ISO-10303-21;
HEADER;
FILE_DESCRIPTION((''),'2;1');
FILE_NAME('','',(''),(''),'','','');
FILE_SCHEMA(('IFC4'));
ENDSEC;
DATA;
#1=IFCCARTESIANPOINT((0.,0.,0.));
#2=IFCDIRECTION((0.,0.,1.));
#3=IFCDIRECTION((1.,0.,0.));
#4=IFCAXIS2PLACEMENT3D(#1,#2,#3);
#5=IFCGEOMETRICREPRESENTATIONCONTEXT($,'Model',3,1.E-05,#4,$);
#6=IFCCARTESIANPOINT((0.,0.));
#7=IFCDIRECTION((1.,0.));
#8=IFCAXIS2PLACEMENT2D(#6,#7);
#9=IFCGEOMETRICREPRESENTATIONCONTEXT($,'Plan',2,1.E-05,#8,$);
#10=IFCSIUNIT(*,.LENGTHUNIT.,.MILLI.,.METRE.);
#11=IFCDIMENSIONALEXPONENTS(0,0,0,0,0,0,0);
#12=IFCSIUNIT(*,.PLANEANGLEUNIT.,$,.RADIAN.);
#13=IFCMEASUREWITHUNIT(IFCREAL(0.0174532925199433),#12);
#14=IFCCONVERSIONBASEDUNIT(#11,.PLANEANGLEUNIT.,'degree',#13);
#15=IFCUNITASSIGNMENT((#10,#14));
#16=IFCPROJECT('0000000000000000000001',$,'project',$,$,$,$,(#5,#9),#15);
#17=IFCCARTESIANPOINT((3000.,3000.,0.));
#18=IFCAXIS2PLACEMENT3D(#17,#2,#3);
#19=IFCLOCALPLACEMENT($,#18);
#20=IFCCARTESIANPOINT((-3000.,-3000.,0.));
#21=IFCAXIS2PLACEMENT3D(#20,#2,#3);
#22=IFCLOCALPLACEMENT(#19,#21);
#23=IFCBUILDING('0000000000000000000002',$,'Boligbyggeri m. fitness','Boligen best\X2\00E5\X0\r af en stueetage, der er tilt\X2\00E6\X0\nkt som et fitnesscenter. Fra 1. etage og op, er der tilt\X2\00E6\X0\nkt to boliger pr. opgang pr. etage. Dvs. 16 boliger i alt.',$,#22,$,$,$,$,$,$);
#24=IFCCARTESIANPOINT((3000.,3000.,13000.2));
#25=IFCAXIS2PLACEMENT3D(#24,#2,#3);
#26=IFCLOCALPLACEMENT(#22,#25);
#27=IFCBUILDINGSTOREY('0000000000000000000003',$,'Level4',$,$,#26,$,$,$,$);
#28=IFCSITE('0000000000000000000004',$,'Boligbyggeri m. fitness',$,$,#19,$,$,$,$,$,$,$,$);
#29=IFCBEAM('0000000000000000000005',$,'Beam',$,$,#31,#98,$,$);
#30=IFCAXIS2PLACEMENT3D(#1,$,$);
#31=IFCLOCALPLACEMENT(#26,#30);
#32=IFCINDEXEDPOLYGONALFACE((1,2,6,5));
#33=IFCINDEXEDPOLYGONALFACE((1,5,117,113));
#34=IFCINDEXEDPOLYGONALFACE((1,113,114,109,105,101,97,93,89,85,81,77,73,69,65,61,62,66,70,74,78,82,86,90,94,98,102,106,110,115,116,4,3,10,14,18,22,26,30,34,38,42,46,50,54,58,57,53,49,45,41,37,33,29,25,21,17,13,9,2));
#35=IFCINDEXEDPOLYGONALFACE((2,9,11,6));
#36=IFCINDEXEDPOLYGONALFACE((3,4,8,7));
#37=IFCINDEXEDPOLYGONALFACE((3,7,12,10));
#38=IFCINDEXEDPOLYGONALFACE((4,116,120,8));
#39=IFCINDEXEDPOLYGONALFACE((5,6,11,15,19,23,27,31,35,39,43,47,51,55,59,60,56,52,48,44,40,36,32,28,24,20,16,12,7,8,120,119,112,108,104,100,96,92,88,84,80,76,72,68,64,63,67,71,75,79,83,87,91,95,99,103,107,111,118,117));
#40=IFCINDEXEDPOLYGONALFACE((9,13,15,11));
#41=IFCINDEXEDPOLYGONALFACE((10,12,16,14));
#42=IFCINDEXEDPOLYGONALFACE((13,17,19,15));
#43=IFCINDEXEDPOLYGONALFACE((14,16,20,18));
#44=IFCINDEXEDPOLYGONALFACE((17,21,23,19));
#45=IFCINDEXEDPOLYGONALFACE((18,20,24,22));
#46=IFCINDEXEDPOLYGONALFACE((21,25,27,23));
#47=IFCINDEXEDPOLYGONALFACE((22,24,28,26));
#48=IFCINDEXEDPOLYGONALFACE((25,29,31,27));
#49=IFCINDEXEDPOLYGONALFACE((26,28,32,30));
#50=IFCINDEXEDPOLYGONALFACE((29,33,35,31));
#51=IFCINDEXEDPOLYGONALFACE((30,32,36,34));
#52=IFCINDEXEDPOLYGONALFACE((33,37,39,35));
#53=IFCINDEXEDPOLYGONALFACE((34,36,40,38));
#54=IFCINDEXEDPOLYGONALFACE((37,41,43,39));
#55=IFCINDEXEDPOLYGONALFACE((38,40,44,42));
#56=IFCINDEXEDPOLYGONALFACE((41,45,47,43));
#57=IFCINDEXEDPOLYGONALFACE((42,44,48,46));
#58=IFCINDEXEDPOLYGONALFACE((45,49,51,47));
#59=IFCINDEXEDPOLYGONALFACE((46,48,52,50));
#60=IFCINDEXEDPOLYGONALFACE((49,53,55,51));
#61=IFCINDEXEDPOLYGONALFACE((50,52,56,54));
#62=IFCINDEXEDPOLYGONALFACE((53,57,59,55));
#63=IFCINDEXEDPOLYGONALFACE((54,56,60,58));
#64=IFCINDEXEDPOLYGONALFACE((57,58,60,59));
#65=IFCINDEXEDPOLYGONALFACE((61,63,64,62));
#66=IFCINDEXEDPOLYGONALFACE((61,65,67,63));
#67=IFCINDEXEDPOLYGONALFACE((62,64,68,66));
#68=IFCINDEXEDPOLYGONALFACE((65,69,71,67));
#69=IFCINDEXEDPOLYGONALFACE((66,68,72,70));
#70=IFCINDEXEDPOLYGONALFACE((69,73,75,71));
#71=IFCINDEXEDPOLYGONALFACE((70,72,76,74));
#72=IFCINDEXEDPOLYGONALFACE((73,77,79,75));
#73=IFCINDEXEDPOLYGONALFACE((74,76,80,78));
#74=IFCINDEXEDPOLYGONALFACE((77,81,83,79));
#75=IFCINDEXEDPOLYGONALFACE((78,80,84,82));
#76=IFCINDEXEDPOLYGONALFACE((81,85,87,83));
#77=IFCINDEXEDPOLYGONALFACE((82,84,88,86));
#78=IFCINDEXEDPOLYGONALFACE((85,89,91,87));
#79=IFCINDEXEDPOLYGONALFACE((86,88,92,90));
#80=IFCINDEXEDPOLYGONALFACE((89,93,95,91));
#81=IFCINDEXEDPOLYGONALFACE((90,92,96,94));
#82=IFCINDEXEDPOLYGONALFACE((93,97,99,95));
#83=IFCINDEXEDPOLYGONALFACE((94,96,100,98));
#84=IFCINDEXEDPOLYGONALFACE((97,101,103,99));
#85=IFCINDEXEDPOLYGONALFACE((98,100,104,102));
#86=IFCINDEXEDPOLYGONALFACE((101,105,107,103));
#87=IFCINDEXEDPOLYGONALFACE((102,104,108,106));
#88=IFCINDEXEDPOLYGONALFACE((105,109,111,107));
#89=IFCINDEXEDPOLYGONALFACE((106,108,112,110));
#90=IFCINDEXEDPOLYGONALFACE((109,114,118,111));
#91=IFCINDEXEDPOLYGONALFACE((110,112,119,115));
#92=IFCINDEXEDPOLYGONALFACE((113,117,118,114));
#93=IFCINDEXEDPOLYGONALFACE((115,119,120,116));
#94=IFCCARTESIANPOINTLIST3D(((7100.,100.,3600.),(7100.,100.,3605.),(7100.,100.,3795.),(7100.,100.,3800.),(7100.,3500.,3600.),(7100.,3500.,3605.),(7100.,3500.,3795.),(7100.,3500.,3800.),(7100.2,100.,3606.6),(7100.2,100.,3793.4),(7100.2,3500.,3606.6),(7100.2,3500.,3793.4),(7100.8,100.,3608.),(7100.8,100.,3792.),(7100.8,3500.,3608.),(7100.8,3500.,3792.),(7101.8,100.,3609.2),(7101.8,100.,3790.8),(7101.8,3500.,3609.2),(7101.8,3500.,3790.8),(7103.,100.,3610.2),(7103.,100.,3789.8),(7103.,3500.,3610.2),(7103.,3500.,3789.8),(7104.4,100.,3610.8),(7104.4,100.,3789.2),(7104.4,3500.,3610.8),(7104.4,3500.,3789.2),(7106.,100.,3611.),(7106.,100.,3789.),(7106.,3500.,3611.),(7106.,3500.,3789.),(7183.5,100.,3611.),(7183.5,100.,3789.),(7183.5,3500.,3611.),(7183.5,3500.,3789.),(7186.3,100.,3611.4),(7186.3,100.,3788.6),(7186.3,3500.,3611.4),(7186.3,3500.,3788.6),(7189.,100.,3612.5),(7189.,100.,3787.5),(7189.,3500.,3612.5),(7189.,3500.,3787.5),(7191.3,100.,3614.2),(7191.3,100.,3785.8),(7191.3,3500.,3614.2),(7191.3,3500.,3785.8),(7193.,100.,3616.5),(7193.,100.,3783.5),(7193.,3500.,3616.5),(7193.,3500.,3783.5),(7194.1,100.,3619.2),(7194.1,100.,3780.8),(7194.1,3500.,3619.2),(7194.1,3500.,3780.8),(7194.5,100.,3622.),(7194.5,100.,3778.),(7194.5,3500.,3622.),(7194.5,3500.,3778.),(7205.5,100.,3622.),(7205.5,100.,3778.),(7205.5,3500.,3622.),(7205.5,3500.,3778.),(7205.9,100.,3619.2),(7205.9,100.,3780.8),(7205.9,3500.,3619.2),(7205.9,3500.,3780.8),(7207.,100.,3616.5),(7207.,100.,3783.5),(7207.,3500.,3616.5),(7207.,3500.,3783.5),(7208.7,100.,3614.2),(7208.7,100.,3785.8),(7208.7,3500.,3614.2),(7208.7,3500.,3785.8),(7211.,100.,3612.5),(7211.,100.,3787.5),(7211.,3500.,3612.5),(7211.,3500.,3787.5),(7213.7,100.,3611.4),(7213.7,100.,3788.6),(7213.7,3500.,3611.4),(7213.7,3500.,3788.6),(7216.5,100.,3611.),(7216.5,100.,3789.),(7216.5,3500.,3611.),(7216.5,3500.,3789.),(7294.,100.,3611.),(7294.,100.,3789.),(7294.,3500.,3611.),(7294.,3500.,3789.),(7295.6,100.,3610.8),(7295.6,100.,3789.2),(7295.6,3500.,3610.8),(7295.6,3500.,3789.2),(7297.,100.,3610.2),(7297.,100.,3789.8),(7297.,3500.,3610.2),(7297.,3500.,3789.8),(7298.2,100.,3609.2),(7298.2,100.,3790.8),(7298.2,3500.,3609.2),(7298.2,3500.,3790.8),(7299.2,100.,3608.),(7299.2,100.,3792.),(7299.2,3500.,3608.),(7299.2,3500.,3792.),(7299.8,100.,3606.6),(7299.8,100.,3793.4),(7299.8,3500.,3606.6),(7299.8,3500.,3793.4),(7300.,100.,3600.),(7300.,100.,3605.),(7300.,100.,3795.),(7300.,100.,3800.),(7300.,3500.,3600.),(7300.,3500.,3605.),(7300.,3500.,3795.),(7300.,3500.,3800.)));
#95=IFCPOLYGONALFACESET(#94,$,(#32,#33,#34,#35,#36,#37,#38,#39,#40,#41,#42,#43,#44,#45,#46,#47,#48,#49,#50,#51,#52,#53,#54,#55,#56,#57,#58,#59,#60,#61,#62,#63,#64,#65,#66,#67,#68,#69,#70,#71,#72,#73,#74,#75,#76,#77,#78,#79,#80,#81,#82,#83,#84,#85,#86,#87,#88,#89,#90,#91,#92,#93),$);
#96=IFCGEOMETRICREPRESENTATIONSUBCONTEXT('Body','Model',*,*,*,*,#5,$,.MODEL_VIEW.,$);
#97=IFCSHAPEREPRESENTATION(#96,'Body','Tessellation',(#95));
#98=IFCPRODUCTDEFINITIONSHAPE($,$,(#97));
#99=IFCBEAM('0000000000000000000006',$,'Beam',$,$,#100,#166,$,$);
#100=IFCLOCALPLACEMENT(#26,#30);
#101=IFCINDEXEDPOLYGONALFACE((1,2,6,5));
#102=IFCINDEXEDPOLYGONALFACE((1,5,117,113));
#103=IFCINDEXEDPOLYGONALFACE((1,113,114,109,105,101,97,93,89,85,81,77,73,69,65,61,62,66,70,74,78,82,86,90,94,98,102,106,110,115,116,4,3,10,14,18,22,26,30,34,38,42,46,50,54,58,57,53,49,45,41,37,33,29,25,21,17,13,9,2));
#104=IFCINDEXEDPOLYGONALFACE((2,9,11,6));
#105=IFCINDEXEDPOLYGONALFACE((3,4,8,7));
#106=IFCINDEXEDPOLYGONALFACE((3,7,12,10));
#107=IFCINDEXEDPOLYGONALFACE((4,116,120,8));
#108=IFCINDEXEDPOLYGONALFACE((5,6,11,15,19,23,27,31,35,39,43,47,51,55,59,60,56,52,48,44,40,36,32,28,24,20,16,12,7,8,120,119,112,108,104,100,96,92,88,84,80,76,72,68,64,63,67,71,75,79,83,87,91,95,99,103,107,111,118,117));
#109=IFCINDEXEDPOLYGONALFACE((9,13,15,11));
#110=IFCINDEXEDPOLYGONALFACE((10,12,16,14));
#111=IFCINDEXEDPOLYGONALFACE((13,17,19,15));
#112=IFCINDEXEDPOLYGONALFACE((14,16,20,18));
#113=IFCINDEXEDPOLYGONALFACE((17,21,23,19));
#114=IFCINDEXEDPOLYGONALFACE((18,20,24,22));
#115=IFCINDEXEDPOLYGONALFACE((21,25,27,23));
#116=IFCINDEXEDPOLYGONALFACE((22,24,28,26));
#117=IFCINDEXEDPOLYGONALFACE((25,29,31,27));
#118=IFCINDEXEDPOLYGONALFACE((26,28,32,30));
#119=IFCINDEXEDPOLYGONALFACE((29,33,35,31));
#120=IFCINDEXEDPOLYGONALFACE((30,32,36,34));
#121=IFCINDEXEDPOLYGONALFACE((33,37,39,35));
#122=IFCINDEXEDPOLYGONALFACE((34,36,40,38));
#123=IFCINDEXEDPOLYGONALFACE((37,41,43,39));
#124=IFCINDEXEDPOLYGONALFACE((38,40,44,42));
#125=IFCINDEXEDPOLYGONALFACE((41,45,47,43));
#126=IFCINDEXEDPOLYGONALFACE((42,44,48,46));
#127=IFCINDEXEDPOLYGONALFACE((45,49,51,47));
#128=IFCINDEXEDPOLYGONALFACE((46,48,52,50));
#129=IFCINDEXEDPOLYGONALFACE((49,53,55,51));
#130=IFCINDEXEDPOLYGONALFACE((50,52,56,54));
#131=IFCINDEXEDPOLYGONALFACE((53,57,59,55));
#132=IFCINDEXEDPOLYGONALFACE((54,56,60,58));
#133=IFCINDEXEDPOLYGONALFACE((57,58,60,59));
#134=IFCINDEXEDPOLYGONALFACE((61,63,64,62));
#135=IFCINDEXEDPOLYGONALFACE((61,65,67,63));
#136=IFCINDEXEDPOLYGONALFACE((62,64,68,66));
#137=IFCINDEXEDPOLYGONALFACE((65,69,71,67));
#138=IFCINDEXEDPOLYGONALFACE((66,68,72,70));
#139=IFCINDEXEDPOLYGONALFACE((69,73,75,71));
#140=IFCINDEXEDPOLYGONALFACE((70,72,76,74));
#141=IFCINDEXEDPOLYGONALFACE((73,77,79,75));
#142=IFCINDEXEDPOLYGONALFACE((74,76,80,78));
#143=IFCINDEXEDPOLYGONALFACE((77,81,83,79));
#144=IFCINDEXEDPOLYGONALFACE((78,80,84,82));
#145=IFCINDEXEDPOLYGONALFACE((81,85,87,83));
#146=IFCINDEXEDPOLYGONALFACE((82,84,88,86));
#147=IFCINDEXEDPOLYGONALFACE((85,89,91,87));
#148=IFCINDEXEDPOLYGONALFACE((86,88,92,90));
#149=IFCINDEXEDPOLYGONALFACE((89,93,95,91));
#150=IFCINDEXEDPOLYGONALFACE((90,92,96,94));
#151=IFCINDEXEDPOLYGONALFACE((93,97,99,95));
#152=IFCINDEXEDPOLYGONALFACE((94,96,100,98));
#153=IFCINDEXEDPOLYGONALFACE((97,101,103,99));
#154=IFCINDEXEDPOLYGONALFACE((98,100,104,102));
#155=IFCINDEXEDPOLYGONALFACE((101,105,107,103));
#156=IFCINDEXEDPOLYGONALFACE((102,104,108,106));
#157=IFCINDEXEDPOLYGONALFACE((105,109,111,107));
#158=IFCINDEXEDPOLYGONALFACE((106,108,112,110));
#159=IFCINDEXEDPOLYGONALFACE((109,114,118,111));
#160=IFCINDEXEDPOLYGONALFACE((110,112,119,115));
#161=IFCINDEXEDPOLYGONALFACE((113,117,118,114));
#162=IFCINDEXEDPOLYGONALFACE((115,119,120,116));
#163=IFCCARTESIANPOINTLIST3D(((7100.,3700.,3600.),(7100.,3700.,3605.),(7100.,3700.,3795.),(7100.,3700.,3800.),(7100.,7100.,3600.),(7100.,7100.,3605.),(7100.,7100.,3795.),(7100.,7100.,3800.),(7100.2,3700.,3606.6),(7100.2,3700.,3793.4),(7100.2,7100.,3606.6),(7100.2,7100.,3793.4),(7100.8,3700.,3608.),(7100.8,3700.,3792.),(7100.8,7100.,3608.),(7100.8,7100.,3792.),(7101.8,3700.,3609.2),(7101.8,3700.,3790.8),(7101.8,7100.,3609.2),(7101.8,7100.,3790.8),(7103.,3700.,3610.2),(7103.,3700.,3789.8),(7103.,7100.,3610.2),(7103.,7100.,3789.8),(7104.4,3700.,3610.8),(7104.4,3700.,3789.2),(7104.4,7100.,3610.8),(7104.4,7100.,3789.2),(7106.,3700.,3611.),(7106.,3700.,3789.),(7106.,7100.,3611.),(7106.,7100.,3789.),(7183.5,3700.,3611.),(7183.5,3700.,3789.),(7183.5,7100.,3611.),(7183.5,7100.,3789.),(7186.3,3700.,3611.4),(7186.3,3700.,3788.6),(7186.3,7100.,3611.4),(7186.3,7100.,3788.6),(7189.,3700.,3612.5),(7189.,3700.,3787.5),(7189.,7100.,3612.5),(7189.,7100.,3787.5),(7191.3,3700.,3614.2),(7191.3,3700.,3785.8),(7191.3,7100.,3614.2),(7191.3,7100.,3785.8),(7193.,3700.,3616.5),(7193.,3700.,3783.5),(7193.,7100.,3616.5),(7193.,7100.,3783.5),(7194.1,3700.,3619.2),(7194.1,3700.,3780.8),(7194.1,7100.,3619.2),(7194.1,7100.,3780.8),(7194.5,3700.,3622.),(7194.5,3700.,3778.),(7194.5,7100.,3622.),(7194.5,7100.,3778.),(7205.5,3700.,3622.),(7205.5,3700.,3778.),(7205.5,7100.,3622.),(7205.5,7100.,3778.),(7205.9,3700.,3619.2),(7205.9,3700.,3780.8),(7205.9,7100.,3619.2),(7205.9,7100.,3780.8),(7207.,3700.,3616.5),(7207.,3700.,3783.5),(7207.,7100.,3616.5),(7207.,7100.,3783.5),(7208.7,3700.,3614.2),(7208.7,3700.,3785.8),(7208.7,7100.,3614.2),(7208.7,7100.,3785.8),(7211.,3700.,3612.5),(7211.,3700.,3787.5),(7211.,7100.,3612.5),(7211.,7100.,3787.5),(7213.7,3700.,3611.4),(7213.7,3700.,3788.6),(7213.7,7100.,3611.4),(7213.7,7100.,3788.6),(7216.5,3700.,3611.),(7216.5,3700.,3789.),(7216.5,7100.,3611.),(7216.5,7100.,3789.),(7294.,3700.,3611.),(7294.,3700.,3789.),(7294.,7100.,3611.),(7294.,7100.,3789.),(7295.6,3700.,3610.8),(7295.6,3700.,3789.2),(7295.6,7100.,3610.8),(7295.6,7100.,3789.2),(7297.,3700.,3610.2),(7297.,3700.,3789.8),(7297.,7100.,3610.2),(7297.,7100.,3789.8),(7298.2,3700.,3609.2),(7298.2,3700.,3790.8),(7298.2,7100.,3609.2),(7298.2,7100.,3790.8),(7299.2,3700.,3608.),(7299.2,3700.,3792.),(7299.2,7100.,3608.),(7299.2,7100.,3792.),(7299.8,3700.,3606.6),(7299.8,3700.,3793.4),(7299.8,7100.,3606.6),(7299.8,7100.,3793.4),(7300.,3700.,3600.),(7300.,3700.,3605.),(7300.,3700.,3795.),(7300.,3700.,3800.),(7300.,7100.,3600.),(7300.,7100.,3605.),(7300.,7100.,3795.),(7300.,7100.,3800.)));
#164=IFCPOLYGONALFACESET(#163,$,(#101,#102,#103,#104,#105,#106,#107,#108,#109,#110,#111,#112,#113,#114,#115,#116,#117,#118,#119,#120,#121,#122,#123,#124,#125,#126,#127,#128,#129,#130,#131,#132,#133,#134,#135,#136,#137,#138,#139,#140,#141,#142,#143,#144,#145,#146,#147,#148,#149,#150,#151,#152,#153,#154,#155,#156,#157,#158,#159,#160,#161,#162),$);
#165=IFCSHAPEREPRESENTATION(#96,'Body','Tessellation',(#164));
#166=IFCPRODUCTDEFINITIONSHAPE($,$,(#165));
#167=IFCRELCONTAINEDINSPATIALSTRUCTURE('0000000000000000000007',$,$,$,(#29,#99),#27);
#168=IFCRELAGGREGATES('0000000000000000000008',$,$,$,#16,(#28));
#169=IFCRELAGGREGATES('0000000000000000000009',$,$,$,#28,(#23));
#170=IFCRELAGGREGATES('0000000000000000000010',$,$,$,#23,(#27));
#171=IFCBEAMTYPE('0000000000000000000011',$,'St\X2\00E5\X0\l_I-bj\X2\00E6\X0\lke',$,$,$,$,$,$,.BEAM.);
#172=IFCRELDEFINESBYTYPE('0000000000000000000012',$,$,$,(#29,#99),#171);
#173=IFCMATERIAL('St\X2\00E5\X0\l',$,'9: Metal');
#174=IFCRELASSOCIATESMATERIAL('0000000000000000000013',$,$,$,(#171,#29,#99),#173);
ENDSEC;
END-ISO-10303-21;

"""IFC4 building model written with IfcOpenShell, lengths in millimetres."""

from ifc_helpers import new_model, entity, si_unit, converted_unit, frame, origin_with_axes, origin_2d_with_axis, place, context, subcontext, project, spatial, i_section, extrude, material, material_profile, profile_set, profile_usage, type_object, element, save


model = new_model("IFC4")

# Units and contexts
model_context = context("Model", 3, precision=1e-05, world=origin_with_axes())
plan_context = context("Plan", 2, precision=1e-05, world=origin_2d_with_axis())
body_context = subcontext(model_context, "Body", "Model", "MODEL_VIEW")
ifc_project = project(units=[si_unit("LENGTHUNIT", "METRE", prefix="MILLI"), converted_unit("PLANEANGLEUNIT", "degree", entity("IfcReal", 0.0174532925199433), si_unit("PLANEANGLEUNIT", "RADIAN"), dimensions=[0, 0, 0, 0, 0, 0, 0])], contexts=[model_context, plan_context])

# Site, building, storey
site_placement = place(None, frame((3000.0, 3000.0, 0.0), z_axis=(0.0, 0.0, 1.0), x_axis=(1.0, 0.0, 0.0)))
site = spatial("IfcSite", under=ifc_project, at=site_placement, Name="Boligbyggeri m. fitness")
building_placement = place(site_placement, frame((-3000.0, -3000.0, 0.0), z_axis=(0.0, 0.0, 1.0), x_axis=(1.0, 0.0, 0.0)))
building = spatial("IfcBuilding", under=site, at=building_placement, Name="Boligbyggeri m. fitness", Description="Boligen består af en stueetage, der er tiltænkt som et fitnesscenter. Fra 1. etage og op, er der tiltænkt to boliger pr. opgang pr. etage. Dvs. 16 boliger i alt.")
storey_placement = place(building_placement, frame((3000.0, 3000.0, 13000.2), z_axis=(0.0, 0.0, 1.0), x_axis=(1.0, 0.0, 0.0)))
storey = spatial("IfcBuildingStorey", under=building, at=storey_placement, Name="Level4")

# Beams
ifc_material_1 = material(Name="Stål", Category="9: Metal")
ifc_material_profile_1 = material_profile(ifc_material_1, i_section(OverallWidth=200.0, OverallDepth=200.0, WebThickness=11.0, FlangeThickness=11.0, FilletRadius=11.0, FlangeEdgeRadius=6.0), Name="Stål", Category="9: Metal")
ifc_profile_set_1 = profile_set([ifc_material_profile_1], Name="NY_I-Profil")
beam_type = type_object("IfcBeamType", Name="Stål_I-bjælke", PredefinedType="BEAM", material=ifc_profile_set_1)
ifc_profile_usage_1 = profile_usage(ifc_profile_set_1, cardinal=9)
beam_1_placement = place(storey_placement, frame((7300.0, 100.0, 3800.0), z_axis=(0.0, 1.0, 0.0), x_axis=(-1.0, 0.0, 0.0)))
element("IfcBeam", 1, at=beam_1_placement, inside=storey, type_object=beam_type, material=ifc_profile_usage_1, Name="Beam", context=body_context, shape_type="SweptSolid", body=[
    extrude(i_section(OverallWidth=200.0, OverallDepth=200.0, WebThickness=11.0, FlangeThickness=11.0, FilletRadius=11.0, FlangeEdgeRadius=6.0), frame((100.0, -100.0, 0.0), z_axis=(0.0, 0.0, 1.0), x_axis=(1.0, 0.0, 0.0)), (0.0, 0.0, 1.0), 3400.0),
])
ifc_profile_usage_2 = profile_usage(ifc_profile_set_1, cardinal=9)
beam_2_placement = place(storey_placement, frame((7300.0, 3700.0, 3800.0), z_axis=(0.0, 1.0, 0.0), x_axis=(-1.0, 0.0, 0.0)))
element("IfcBeam", 2, at=beam_2_placement, inside=storey, type_object=beam_type, material=ifc_profile_usage_2, Name="Beam", context=body_context, shape_type="SweptSolid", body=[
    extrude(i_section(OverallWidth=200.0, OverallDepth=200.0, WebThickness=11.0, FlangeThickness=11.0, FilletRadius=11.0, FlangeEdgeRadius=6.0), frame((100.0, -100.0, 0.0), z_axis=(0.0, 0.0, 1.0), x_axis=(1.0, 0.0, 0.0)), (0.0, 0.0, 1.0), 3400.0),
])

save(model, "model.ifc")
